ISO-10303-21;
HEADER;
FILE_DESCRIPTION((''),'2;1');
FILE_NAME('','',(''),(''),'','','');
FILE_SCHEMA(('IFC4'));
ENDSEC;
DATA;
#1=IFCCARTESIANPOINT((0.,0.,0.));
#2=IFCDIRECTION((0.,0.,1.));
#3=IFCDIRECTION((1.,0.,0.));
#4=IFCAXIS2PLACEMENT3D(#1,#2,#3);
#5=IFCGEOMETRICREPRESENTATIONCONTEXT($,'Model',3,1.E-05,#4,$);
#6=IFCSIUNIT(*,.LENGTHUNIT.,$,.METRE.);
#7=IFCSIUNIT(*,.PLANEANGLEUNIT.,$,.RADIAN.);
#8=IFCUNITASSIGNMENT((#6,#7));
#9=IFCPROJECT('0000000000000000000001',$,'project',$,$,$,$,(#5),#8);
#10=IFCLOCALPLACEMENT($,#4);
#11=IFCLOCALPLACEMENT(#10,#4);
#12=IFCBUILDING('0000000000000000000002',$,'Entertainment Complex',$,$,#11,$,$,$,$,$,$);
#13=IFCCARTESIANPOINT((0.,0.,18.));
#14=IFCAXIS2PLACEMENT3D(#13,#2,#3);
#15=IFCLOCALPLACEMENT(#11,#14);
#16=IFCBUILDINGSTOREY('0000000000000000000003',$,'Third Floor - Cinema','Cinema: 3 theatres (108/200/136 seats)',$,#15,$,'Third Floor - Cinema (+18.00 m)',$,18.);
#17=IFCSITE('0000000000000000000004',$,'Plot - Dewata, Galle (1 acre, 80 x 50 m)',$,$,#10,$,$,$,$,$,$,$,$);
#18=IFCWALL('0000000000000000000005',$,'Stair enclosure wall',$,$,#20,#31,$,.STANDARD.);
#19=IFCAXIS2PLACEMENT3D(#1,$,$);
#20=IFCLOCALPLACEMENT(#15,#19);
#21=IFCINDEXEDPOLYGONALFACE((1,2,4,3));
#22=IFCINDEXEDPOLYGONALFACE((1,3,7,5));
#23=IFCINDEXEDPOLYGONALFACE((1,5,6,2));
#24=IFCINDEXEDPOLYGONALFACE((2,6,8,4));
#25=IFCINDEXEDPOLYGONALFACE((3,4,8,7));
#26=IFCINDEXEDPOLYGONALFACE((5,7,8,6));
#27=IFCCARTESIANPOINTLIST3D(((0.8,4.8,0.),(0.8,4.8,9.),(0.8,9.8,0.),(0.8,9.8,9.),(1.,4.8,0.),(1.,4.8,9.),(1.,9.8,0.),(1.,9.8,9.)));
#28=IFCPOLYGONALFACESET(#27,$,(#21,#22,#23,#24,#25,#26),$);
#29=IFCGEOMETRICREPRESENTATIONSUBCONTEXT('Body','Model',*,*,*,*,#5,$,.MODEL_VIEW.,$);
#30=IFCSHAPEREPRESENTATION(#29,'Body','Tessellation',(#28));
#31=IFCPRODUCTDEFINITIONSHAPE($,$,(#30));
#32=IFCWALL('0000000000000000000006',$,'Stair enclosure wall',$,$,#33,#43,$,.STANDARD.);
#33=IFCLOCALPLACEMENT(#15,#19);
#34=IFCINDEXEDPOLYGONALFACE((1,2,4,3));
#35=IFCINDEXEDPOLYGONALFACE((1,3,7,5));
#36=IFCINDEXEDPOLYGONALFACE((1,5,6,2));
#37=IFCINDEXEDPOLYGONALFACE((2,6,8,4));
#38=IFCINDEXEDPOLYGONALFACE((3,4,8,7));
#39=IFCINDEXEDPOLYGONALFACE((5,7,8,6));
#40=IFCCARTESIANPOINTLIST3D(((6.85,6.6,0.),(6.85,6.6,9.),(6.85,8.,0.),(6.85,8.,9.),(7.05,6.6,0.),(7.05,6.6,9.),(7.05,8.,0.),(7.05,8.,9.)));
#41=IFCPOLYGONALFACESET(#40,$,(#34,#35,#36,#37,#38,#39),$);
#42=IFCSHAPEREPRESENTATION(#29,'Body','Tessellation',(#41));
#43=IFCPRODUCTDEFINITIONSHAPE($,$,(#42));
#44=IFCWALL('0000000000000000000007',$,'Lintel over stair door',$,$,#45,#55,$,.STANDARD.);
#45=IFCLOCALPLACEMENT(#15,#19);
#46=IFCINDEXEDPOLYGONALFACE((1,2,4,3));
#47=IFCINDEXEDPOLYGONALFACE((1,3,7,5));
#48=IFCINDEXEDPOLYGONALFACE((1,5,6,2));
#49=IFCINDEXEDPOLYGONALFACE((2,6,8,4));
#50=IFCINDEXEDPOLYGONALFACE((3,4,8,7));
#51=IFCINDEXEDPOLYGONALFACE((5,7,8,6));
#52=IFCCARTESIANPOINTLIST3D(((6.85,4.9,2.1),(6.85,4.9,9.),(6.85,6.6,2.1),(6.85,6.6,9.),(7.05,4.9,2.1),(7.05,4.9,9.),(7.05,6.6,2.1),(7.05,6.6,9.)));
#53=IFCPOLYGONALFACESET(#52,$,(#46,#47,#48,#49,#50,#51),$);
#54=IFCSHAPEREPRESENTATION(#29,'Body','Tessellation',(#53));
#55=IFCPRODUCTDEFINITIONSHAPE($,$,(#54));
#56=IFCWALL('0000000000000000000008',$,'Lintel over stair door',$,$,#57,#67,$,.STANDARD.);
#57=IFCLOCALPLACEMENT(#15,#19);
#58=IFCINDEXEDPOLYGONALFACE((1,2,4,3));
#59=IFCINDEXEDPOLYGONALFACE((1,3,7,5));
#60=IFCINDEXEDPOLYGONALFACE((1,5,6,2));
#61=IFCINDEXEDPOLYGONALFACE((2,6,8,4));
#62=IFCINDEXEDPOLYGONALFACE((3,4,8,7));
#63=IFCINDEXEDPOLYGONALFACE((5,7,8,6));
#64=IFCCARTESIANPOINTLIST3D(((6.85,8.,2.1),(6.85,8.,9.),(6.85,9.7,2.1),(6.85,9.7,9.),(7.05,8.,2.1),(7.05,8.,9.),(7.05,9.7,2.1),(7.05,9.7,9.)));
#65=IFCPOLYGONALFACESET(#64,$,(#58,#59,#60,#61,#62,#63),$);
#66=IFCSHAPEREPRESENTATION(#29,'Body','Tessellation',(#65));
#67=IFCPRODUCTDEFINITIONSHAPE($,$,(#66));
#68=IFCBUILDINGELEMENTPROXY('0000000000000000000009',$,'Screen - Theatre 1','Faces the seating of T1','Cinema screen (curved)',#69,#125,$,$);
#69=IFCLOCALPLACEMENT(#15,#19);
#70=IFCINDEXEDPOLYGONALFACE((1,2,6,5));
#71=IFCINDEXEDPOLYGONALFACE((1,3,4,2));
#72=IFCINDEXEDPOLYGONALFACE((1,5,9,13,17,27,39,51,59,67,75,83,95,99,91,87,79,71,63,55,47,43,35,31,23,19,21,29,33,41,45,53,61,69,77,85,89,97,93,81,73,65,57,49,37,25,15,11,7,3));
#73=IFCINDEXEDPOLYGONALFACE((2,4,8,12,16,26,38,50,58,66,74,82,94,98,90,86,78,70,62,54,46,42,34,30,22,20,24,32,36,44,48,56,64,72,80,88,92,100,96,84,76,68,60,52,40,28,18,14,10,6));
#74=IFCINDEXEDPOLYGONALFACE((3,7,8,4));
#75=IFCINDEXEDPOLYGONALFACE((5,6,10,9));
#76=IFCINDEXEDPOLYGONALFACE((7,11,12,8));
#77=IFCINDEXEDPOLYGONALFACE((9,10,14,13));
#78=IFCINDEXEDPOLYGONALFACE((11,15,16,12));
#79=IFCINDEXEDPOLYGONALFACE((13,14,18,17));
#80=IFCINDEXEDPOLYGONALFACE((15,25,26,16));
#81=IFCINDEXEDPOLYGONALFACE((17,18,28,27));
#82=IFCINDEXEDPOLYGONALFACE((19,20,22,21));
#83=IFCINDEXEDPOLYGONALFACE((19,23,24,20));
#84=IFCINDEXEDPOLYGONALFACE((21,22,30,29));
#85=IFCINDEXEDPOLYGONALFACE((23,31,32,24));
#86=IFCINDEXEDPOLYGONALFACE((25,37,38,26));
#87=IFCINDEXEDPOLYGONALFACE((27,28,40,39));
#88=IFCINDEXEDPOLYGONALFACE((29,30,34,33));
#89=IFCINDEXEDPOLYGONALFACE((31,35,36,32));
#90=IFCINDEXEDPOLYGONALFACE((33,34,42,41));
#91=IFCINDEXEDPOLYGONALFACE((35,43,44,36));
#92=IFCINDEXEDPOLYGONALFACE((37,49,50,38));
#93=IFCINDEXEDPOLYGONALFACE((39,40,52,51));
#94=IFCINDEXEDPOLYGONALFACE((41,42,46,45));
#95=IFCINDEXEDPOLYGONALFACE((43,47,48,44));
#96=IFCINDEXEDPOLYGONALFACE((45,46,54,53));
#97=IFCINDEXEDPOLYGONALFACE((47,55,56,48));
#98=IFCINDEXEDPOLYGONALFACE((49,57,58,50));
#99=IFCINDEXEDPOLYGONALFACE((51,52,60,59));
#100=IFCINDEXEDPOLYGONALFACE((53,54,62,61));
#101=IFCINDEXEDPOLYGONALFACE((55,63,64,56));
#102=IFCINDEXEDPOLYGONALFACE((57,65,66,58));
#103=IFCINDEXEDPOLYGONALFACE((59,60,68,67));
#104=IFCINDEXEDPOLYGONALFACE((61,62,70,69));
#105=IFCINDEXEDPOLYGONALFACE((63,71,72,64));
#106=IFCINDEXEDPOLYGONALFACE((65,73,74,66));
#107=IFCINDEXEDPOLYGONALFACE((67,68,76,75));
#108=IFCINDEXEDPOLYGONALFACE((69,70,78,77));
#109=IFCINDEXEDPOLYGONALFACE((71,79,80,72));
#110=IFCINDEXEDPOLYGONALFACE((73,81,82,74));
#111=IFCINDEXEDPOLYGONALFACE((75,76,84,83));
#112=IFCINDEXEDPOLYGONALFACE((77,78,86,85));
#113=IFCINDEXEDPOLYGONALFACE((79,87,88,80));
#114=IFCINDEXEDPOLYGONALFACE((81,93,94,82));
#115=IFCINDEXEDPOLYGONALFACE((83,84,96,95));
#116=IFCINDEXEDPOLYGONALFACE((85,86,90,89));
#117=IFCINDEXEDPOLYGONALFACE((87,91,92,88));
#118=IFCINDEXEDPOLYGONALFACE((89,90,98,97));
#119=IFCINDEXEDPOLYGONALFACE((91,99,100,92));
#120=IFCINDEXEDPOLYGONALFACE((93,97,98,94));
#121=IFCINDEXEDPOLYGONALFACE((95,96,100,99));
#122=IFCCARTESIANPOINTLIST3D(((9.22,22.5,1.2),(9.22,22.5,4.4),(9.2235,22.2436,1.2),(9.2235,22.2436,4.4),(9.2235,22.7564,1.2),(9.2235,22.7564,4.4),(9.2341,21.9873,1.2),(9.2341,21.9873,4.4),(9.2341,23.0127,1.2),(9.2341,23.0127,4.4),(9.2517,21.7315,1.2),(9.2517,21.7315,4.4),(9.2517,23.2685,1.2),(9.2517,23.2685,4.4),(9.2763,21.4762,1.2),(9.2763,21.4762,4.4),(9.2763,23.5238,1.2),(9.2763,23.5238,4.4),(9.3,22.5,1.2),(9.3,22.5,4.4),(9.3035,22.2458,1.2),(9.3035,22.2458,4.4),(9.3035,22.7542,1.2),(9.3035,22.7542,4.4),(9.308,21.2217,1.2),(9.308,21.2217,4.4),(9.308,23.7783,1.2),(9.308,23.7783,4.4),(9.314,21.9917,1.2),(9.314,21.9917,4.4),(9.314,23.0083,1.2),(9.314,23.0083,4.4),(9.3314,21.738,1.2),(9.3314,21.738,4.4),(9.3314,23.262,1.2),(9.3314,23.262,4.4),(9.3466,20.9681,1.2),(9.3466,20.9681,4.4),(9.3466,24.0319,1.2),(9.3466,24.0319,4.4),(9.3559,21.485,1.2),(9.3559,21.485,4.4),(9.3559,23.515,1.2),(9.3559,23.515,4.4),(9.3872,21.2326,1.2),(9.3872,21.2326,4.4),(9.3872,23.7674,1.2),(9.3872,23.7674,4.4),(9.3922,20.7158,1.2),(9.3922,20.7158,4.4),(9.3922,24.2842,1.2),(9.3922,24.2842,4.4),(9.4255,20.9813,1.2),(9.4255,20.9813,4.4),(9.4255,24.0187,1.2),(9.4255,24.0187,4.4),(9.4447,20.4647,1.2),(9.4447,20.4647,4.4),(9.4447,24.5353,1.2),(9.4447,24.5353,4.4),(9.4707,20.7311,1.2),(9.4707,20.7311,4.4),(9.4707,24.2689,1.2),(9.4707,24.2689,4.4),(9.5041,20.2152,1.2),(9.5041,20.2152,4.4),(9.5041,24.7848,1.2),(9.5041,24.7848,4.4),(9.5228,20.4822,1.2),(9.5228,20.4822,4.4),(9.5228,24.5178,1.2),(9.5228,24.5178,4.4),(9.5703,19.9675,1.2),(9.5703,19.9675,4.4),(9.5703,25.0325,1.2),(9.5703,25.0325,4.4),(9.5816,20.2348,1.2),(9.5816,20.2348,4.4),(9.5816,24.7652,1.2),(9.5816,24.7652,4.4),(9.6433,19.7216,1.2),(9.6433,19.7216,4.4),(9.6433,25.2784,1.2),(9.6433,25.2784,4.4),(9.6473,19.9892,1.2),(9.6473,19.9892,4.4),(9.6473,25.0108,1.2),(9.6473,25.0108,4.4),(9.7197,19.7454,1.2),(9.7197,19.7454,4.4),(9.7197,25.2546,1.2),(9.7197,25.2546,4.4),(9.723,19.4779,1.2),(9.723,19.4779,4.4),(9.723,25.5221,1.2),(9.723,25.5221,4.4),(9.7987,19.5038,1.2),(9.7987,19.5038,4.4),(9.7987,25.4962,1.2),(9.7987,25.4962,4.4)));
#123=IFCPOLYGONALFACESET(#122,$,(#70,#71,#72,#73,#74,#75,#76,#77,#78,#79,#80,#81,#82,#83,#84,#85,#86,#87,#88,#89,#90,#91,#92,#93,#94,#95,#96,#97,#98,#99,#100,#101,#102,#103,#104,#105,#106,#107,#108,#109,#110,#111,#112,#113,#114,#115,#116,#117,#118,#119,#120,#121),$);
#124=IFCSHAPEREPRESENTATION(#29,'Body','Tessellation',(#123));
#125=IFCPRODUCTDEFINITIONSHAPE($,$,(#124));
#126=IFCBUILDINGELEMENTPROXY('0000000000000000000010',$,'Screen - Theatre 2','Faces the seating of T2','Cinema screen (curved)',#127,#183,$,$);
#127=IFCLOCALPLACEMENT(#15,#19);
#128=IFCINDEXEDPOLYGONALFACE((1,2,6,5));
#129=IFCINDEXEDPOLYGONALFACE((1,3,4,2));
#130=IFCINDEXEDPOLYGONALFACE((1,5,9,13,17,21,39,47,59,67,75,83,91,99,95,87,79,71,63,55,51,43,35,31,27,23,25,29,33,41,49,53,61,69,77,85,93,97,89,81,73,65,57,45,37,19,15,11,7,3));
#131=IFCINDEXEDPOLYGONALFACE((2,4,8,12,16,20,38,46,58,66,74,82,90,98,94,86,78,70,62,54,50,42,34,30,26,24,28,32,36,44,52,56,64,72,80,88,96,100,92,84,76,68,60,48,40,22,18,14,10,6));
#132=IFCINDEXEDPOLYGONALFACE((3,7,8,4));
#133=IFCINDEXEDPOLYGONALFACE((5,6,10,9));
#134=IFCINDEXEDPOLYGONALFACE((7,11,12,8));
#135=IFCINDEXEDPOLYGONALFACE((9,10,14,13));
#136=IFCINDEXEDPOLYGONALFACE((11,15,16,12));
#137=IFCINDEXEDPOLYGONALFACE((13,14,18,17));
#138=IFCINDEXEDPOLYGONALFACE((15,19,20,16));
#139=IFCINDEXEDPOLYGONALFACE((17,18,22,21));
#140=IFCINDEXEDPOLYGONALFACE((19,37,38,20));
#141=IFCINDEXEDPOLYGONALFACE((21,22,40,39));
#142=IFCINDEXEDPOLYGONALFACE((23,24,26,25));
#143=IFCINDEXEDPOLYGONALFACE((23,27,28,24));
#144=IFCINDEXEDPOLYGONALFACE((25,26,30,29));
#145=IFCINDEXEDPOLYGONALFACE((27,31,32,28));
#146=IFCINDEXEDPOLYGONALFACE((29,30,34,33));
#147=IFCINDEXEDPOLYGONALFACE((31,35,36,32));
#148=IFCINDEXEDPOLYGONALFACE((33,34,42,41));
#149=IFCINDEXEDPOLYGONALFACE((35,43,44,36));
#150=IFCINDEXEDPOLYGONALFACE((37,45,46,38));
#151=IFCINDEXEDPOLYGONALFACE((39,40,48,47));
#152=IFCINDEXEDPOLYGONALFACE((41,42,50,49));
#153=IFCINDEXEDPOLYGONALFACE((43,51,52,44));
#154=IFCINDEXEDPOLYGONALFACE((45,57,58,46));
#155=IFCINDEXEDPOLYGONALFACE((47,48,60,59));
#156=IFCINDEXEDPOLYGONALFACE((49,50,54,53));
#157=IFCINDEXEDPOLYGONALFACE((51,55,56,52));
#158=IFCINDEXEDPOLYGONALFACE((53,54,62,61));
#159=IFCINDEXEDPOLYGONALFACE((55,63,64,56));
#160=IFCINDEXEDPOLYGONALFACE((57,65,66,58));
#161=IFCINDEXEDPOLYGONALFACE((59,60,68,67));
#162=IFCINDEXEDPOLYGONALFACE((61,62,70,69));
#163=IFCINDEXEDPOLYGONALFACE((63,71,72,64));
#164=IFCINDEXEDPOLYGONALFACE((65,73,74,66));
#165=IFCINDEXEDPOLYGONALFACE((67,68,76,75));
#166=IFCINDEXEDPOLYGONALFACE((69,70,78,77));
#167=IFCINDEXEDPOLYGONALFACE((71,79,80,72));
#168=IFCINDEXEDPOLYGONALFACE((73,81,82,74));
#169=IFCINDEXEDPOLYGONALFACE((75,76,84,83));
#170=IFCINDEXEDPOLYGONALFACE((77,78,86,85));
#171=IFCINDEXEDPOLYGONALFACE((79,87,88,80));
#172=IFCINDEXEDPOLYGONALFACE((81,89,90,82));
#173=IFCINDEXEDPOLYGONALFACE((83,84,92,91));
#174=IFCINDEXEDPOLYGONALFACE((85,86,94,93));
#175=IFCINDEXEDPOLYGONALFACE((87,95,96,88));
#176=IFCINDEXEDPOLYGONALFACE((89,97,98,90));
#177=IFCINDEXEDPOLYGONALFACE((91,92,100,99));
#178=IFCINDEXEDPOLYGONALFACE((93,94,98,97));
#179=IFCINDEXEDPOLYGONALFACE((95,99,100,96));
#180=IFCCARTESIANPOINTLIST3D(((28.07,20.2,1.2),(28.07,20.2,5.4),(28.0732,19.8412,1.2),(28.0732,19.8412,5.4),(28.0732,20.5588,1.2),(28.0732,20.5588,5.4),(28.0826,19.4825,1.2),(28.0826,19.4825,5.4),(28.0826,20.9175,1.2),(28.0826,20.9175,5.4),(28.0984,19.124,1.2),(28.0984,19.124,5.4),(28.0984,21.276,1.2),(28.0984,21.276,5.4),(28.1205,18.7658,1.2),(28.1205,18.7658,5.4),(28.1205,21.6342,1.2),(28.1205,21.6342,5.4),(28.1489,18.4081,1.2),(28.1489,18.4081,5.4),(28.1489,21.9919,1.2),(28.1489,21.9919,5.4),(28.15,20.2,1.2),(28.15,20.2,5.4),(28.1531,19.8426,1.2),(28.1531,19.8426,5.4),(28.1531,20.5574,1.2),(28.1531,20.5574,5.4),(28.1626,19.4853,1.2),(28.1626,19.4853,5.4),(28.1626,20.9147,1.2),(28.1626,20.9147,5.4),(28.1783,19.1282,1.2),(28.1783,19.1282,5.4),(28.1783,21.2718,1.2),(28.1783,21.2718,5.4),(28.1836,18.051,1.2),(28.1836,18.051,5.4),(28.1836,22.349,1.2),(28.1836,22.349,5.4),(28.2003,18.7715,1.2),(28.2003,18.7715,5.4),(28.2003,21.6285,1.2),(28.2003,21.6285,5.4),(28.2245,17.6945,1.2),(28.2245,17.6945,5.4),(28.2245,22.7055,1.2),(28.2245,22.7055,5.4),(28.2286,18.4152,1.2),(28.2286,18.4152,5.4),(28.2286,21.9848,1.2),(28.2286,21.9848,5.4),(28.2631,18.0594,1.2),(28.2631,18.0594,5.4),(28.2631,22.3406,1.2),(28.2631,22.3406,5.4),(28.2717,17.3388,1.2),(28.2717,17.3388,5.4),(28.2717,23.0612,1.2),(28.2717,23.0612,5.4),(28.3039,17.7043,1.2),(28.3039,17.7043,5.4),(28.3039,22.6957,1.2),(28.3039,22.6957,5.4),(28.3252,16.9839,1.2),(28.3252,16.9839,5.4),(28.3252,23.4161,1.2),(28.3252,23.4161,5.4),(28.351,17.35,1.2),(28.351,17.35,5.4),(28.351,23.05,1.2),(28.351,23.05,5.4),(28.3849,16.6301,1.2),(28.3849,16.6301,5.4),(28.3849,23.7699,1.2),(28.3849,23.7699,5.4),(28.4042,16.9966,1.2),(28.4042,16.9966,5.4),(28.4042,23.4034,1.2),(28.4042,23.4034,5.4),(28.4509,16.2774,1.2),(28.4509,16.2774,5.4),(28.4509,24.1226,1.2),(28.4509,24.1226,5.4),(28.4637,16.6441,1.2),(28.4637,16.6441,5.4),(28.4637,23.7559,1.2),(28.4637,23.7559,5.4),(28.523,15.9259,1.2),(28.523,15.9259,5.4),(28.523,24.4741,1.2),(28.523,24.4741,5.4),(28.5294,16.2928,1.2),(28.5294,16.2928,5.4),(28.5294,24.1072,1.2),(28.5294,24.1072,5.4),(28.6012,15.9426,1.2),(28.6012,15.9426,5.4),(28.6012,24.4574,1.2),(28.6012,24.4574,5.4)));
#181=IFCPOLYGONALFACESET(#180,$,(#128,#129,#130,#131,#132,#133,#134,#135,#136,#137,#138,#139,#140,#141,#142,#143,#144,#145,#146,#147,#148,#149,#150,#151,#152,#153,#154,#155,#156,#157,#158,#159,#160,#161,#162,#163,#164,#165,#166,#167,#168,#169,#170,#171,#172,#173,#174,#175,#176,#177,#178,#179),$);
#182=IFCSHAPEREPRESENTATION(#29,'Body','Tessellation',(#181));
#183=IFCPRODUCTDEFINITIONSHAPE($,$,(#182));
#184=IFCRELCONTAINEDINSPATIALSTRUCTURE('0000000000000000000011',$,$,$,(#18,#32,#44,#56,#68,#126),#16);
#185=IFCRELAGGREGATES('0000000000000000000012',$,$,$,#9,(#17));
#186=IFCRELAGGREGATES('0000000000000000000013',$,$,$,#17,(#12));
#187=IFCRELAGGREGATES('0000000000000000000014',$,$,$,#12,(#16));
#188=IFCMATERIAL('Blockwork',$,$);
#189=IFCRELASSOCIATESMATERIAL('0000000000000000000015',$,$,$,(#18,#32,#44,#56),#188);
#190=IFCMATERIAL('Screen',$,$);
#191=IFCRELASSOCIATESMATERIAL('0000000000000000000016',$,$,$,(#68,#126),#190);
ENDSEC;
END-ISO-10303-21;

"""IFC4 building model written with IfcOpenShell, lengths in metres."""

from ifc_helpers import new_model, si_unit, frame, origin_with_axes, place, context, subcontext, project, spatial, polyline, outline, extrude, material, element, save


model = new_model("IFC4")

# Units and contexts
model_context = context("Model", 3, precision=1e-05, world=origin_with_axes())
body_context = subcontext(model_context, "Body", "Model", "MODEL_VIEW")
ifc_project = project(units=[si_unit("LENGTHUNIT", "METRE"), si_unit("PLANEANGLEUNIT", "RADIAN")], contexts=[model_context])

# Site, building, storey
site_placement = place(None, origin_with_axes())
site = spatial("IfcSite", under=ifc_project, at=site_placement, Name="Plot - Dewata, Galle (1 acre, 80 x 50 m)")
building_placement = place(site_placement, origin_with_axes())
building = spatial("IfcBuilding", under=site, at=building_placement, Name="Entertainment Complex")
storey_placement = place(building_placement, frame((0.0, 0.0, 18.0), z_axis=(0.0, 0.0, 1.0), x_axis=(1.0, 0.0, 0.0)))
storey = spatial("IfcBuildingStorey", under=building, at=storey_placement, Name="Third Floor - Cinema", Description="Cinema: 3 theatres (108/200/136 seats)", LongName="Third Floor - Cinema (+18.00 m)", Elevation=18.0)

# Walls
ifc_material_1 = material(Name="Blockwork")
wall_1_placement = place(storey_placement, frame((0.9, 4.8, 0.0), z_axis=(0.0, 0.0, 1.0), x_axis=(0.0, 1.0, 0.0)))
element("IfcWall", 1, at=wall_1_placement, inside=storey, material=ifc_material_1, Name="Stair enclosure wall", PredefinedType="STANDARD", context=body_context, shape_type="SweptSolid", body=[
    extrude(outline(polyline([(0.0, -0.1), (5.0, -0.1), (5.0, 0.1), (0.0, 0.1), (0.0, -0.1)])), origin_with_axes(), (0.0, 0.0, 1.0), 9.0),
])
wall_2_placement = place(storey_placement, frame((6.95, 6.6, 0.0), z_axis=(0.0, 0.0, 1.0), x_axis=(0.0, 1.0, 0.0)))
element("IfcWall", 2, at=wall_2_placement, inside=storey, material=ifc_material_1, Name="Stair enclosure wall", PredefinedType="STANDARD", context=body_context, shape_type="SweptSolid", body=[
    extrude(outline(polyline([(0.0, -0.1), (1.4, -0.1), (1.4, 0.1), (0.0, 0.1), (0.0, -0.1)])), origin_with_axes(), (0.0, 0.0, 1.0), 9.0),
])
for number, where, z_axis, x_axis, name in (
    (3, (6.95, 4.9, 2.1), (0.0, 0.0, 1.0), (0.0, 1.0, 0.0), "Lintel over stair door"),
    (4, (6.95, 8.0, 2.1), (0.0, 0.0, 1.0), (0.0, 1.0, 0.0), "Lintel over stair door"),
):
    element("IfcWall", number, at=place(storey_placement, frame(where, z_axis=z_axis, x_axis=x_axis)), inside=storey, material=ifc_material_1, Name=name, PredefinedType="STANDARD", context=body_context, shape_type="SweptSolid", body=[
        extrude(outline(polyline([(0.0, -0.1), (1.7, -0.1), (1.7, 0.1), (0.0, 0.1), (0.0, -0.1)])), origin_with_axes(), (0.0, 0.0, 1.0), 6.9),
    ])

# Building element proxies
ifc_material_2 = material(Name="Screen")
proxy_1_placement = place(storey_placement, origin_with_axes())
element("IfcBuildingElementProxy", 5, at=proxy_1_placement, inside=storey, material=ifc_material_2, Name="Screen - Theatre 1", Description="Faces the seating of T1", ObjectType="Cinema screen (curved)", context=body_context, shape_type="SweptSolid", body=[
    extrude(outline(polyline([(9.723, 25.5221), (9.6433, 25.2784), (9.5703, 25.0325), (9.5041, 24.7848), (9.4447, 24.5353), (9.3922, 24.2842), (9.3466, 24.0319), (9.308, 23.7783), (9.2763, 23.5238), (9.2517, 23.2685), (9.2341, 23.0127), (9.2235, 22.7564), (9.22, 22.5), (9.2235, 22.2436), (9.2341, 21.9873), (9.2517, 21.7315), (9.2763, 21.4762), (9.308, 21.2217), (9.3466, 20.9681), (9.3922, 20.7158), (9.4447, 20.4647), (9.5041, 20.2152), (9.5703, 19.9675), (9.6433, 19.7216), (9.723, 19.4779), (9.7987, 19.5038), (9.7197, 19.7454), (9.6473, 19.9892), (9.5816, 20.2348), (9.5228, 20.4822), (9.4707, 20.7311), (9.4255, 20.9813), (9.3872, 21.2326), (9.3559, 21.485), (9.3314, 21.738), (9.314, 21.9917), (9.3035, 22.2458), (9.3, 22.5), (9.3035, 22.7542), (9.314, 23.0083), (9.3314, 23.262), (9.3559, 23.515), (9.3872, 23.7674), (9.4255, 24.0187), (9.4707, 24.2689), (9.5228, 24.5178), (9.5816, 24.7652), (9.6473, 25.0108), (9.7197, 25.2546), (9.7987, 25.4962), (9.723, 25.5221)])), frame((0.0, 0.0, 1.2), z_axis=(0.0, 0.0, 1.0), x_axis=(1.0, 0.0, 0.0)), (0.0, 0.0, 1.0), 3.2),
])
proxy_2_placement = place(storey_placement, origin_with_axes())
element("IfcBuildingElementProxy", 6, at=proxy_2_placement, inside=storey, material=ifc_material_2, Name="Screen - Theatre 2", Description="Faces the seating of T2", ObjectType="Cinema screen (curved)", context=body_context, shape_type="SweptSolid", body=[
    extrude(outline(polyline([(28.523, 24.4741), (28.4509, 24.1226), (28.3849, 23.7699), (28.3252, 23.4161), (28.2717, 23.0612), (28.2245, 22.7055), (28.1836, 22.349), (28.1489, 21.9919), (28.1205, 21.6342), (28.0984, 21.276), (28.0826, 20.9175), (28.0732, 20.5588), (28.07, 20.2), (28.0732, 19.8412), (28.0826, 19.4825), (28.0984, 19.124), (28.1205, 18.7658), (28.1489, 18.4081), (28.1836, 18.051), (28.2245, 17.6945), (28.2717, 17.3388), (28.3252, 16.9839), (28.3849, 16.6301), (28.4509, 16.2774), (28.523, 15.9259), (28.6012, 15.9426), (28.5294, 16.2928), (28.4637, 16.6441), (28.4042, 16.9966), (28.351, 17.35), (28.3039, 17.7043), (28.2631, 18.0594), (28.2286, 18.4152), (28.2003, 18.7715), (28.1783, 19.1282), (28.1626, 19.4853), (28.1531, 19.8426), (28.15, 20.2), (28.1531, 20.5574), (28.1626, 20.9147), (28.1783, 21.2718), (28.2003, 21.6285), (28.2286, 21.9848), (28.2631, 22.3406), (28.3039, 22.6957), (28.351, 23.05), (28.4042, 23.4034), (28.4637, 23.7559), (28.5294, 24.1072), (28.6012, 24.4574), (28.523, 24.4741)])), frame((0.0, 0.0, 1.2), z_axis=(0.0, 0.0, 1.0), x_axis=(1.0, 0.0, 0.0)), (0.0, 0.0, 1.0), 4.2),
])

save(model, "model.ifc")
